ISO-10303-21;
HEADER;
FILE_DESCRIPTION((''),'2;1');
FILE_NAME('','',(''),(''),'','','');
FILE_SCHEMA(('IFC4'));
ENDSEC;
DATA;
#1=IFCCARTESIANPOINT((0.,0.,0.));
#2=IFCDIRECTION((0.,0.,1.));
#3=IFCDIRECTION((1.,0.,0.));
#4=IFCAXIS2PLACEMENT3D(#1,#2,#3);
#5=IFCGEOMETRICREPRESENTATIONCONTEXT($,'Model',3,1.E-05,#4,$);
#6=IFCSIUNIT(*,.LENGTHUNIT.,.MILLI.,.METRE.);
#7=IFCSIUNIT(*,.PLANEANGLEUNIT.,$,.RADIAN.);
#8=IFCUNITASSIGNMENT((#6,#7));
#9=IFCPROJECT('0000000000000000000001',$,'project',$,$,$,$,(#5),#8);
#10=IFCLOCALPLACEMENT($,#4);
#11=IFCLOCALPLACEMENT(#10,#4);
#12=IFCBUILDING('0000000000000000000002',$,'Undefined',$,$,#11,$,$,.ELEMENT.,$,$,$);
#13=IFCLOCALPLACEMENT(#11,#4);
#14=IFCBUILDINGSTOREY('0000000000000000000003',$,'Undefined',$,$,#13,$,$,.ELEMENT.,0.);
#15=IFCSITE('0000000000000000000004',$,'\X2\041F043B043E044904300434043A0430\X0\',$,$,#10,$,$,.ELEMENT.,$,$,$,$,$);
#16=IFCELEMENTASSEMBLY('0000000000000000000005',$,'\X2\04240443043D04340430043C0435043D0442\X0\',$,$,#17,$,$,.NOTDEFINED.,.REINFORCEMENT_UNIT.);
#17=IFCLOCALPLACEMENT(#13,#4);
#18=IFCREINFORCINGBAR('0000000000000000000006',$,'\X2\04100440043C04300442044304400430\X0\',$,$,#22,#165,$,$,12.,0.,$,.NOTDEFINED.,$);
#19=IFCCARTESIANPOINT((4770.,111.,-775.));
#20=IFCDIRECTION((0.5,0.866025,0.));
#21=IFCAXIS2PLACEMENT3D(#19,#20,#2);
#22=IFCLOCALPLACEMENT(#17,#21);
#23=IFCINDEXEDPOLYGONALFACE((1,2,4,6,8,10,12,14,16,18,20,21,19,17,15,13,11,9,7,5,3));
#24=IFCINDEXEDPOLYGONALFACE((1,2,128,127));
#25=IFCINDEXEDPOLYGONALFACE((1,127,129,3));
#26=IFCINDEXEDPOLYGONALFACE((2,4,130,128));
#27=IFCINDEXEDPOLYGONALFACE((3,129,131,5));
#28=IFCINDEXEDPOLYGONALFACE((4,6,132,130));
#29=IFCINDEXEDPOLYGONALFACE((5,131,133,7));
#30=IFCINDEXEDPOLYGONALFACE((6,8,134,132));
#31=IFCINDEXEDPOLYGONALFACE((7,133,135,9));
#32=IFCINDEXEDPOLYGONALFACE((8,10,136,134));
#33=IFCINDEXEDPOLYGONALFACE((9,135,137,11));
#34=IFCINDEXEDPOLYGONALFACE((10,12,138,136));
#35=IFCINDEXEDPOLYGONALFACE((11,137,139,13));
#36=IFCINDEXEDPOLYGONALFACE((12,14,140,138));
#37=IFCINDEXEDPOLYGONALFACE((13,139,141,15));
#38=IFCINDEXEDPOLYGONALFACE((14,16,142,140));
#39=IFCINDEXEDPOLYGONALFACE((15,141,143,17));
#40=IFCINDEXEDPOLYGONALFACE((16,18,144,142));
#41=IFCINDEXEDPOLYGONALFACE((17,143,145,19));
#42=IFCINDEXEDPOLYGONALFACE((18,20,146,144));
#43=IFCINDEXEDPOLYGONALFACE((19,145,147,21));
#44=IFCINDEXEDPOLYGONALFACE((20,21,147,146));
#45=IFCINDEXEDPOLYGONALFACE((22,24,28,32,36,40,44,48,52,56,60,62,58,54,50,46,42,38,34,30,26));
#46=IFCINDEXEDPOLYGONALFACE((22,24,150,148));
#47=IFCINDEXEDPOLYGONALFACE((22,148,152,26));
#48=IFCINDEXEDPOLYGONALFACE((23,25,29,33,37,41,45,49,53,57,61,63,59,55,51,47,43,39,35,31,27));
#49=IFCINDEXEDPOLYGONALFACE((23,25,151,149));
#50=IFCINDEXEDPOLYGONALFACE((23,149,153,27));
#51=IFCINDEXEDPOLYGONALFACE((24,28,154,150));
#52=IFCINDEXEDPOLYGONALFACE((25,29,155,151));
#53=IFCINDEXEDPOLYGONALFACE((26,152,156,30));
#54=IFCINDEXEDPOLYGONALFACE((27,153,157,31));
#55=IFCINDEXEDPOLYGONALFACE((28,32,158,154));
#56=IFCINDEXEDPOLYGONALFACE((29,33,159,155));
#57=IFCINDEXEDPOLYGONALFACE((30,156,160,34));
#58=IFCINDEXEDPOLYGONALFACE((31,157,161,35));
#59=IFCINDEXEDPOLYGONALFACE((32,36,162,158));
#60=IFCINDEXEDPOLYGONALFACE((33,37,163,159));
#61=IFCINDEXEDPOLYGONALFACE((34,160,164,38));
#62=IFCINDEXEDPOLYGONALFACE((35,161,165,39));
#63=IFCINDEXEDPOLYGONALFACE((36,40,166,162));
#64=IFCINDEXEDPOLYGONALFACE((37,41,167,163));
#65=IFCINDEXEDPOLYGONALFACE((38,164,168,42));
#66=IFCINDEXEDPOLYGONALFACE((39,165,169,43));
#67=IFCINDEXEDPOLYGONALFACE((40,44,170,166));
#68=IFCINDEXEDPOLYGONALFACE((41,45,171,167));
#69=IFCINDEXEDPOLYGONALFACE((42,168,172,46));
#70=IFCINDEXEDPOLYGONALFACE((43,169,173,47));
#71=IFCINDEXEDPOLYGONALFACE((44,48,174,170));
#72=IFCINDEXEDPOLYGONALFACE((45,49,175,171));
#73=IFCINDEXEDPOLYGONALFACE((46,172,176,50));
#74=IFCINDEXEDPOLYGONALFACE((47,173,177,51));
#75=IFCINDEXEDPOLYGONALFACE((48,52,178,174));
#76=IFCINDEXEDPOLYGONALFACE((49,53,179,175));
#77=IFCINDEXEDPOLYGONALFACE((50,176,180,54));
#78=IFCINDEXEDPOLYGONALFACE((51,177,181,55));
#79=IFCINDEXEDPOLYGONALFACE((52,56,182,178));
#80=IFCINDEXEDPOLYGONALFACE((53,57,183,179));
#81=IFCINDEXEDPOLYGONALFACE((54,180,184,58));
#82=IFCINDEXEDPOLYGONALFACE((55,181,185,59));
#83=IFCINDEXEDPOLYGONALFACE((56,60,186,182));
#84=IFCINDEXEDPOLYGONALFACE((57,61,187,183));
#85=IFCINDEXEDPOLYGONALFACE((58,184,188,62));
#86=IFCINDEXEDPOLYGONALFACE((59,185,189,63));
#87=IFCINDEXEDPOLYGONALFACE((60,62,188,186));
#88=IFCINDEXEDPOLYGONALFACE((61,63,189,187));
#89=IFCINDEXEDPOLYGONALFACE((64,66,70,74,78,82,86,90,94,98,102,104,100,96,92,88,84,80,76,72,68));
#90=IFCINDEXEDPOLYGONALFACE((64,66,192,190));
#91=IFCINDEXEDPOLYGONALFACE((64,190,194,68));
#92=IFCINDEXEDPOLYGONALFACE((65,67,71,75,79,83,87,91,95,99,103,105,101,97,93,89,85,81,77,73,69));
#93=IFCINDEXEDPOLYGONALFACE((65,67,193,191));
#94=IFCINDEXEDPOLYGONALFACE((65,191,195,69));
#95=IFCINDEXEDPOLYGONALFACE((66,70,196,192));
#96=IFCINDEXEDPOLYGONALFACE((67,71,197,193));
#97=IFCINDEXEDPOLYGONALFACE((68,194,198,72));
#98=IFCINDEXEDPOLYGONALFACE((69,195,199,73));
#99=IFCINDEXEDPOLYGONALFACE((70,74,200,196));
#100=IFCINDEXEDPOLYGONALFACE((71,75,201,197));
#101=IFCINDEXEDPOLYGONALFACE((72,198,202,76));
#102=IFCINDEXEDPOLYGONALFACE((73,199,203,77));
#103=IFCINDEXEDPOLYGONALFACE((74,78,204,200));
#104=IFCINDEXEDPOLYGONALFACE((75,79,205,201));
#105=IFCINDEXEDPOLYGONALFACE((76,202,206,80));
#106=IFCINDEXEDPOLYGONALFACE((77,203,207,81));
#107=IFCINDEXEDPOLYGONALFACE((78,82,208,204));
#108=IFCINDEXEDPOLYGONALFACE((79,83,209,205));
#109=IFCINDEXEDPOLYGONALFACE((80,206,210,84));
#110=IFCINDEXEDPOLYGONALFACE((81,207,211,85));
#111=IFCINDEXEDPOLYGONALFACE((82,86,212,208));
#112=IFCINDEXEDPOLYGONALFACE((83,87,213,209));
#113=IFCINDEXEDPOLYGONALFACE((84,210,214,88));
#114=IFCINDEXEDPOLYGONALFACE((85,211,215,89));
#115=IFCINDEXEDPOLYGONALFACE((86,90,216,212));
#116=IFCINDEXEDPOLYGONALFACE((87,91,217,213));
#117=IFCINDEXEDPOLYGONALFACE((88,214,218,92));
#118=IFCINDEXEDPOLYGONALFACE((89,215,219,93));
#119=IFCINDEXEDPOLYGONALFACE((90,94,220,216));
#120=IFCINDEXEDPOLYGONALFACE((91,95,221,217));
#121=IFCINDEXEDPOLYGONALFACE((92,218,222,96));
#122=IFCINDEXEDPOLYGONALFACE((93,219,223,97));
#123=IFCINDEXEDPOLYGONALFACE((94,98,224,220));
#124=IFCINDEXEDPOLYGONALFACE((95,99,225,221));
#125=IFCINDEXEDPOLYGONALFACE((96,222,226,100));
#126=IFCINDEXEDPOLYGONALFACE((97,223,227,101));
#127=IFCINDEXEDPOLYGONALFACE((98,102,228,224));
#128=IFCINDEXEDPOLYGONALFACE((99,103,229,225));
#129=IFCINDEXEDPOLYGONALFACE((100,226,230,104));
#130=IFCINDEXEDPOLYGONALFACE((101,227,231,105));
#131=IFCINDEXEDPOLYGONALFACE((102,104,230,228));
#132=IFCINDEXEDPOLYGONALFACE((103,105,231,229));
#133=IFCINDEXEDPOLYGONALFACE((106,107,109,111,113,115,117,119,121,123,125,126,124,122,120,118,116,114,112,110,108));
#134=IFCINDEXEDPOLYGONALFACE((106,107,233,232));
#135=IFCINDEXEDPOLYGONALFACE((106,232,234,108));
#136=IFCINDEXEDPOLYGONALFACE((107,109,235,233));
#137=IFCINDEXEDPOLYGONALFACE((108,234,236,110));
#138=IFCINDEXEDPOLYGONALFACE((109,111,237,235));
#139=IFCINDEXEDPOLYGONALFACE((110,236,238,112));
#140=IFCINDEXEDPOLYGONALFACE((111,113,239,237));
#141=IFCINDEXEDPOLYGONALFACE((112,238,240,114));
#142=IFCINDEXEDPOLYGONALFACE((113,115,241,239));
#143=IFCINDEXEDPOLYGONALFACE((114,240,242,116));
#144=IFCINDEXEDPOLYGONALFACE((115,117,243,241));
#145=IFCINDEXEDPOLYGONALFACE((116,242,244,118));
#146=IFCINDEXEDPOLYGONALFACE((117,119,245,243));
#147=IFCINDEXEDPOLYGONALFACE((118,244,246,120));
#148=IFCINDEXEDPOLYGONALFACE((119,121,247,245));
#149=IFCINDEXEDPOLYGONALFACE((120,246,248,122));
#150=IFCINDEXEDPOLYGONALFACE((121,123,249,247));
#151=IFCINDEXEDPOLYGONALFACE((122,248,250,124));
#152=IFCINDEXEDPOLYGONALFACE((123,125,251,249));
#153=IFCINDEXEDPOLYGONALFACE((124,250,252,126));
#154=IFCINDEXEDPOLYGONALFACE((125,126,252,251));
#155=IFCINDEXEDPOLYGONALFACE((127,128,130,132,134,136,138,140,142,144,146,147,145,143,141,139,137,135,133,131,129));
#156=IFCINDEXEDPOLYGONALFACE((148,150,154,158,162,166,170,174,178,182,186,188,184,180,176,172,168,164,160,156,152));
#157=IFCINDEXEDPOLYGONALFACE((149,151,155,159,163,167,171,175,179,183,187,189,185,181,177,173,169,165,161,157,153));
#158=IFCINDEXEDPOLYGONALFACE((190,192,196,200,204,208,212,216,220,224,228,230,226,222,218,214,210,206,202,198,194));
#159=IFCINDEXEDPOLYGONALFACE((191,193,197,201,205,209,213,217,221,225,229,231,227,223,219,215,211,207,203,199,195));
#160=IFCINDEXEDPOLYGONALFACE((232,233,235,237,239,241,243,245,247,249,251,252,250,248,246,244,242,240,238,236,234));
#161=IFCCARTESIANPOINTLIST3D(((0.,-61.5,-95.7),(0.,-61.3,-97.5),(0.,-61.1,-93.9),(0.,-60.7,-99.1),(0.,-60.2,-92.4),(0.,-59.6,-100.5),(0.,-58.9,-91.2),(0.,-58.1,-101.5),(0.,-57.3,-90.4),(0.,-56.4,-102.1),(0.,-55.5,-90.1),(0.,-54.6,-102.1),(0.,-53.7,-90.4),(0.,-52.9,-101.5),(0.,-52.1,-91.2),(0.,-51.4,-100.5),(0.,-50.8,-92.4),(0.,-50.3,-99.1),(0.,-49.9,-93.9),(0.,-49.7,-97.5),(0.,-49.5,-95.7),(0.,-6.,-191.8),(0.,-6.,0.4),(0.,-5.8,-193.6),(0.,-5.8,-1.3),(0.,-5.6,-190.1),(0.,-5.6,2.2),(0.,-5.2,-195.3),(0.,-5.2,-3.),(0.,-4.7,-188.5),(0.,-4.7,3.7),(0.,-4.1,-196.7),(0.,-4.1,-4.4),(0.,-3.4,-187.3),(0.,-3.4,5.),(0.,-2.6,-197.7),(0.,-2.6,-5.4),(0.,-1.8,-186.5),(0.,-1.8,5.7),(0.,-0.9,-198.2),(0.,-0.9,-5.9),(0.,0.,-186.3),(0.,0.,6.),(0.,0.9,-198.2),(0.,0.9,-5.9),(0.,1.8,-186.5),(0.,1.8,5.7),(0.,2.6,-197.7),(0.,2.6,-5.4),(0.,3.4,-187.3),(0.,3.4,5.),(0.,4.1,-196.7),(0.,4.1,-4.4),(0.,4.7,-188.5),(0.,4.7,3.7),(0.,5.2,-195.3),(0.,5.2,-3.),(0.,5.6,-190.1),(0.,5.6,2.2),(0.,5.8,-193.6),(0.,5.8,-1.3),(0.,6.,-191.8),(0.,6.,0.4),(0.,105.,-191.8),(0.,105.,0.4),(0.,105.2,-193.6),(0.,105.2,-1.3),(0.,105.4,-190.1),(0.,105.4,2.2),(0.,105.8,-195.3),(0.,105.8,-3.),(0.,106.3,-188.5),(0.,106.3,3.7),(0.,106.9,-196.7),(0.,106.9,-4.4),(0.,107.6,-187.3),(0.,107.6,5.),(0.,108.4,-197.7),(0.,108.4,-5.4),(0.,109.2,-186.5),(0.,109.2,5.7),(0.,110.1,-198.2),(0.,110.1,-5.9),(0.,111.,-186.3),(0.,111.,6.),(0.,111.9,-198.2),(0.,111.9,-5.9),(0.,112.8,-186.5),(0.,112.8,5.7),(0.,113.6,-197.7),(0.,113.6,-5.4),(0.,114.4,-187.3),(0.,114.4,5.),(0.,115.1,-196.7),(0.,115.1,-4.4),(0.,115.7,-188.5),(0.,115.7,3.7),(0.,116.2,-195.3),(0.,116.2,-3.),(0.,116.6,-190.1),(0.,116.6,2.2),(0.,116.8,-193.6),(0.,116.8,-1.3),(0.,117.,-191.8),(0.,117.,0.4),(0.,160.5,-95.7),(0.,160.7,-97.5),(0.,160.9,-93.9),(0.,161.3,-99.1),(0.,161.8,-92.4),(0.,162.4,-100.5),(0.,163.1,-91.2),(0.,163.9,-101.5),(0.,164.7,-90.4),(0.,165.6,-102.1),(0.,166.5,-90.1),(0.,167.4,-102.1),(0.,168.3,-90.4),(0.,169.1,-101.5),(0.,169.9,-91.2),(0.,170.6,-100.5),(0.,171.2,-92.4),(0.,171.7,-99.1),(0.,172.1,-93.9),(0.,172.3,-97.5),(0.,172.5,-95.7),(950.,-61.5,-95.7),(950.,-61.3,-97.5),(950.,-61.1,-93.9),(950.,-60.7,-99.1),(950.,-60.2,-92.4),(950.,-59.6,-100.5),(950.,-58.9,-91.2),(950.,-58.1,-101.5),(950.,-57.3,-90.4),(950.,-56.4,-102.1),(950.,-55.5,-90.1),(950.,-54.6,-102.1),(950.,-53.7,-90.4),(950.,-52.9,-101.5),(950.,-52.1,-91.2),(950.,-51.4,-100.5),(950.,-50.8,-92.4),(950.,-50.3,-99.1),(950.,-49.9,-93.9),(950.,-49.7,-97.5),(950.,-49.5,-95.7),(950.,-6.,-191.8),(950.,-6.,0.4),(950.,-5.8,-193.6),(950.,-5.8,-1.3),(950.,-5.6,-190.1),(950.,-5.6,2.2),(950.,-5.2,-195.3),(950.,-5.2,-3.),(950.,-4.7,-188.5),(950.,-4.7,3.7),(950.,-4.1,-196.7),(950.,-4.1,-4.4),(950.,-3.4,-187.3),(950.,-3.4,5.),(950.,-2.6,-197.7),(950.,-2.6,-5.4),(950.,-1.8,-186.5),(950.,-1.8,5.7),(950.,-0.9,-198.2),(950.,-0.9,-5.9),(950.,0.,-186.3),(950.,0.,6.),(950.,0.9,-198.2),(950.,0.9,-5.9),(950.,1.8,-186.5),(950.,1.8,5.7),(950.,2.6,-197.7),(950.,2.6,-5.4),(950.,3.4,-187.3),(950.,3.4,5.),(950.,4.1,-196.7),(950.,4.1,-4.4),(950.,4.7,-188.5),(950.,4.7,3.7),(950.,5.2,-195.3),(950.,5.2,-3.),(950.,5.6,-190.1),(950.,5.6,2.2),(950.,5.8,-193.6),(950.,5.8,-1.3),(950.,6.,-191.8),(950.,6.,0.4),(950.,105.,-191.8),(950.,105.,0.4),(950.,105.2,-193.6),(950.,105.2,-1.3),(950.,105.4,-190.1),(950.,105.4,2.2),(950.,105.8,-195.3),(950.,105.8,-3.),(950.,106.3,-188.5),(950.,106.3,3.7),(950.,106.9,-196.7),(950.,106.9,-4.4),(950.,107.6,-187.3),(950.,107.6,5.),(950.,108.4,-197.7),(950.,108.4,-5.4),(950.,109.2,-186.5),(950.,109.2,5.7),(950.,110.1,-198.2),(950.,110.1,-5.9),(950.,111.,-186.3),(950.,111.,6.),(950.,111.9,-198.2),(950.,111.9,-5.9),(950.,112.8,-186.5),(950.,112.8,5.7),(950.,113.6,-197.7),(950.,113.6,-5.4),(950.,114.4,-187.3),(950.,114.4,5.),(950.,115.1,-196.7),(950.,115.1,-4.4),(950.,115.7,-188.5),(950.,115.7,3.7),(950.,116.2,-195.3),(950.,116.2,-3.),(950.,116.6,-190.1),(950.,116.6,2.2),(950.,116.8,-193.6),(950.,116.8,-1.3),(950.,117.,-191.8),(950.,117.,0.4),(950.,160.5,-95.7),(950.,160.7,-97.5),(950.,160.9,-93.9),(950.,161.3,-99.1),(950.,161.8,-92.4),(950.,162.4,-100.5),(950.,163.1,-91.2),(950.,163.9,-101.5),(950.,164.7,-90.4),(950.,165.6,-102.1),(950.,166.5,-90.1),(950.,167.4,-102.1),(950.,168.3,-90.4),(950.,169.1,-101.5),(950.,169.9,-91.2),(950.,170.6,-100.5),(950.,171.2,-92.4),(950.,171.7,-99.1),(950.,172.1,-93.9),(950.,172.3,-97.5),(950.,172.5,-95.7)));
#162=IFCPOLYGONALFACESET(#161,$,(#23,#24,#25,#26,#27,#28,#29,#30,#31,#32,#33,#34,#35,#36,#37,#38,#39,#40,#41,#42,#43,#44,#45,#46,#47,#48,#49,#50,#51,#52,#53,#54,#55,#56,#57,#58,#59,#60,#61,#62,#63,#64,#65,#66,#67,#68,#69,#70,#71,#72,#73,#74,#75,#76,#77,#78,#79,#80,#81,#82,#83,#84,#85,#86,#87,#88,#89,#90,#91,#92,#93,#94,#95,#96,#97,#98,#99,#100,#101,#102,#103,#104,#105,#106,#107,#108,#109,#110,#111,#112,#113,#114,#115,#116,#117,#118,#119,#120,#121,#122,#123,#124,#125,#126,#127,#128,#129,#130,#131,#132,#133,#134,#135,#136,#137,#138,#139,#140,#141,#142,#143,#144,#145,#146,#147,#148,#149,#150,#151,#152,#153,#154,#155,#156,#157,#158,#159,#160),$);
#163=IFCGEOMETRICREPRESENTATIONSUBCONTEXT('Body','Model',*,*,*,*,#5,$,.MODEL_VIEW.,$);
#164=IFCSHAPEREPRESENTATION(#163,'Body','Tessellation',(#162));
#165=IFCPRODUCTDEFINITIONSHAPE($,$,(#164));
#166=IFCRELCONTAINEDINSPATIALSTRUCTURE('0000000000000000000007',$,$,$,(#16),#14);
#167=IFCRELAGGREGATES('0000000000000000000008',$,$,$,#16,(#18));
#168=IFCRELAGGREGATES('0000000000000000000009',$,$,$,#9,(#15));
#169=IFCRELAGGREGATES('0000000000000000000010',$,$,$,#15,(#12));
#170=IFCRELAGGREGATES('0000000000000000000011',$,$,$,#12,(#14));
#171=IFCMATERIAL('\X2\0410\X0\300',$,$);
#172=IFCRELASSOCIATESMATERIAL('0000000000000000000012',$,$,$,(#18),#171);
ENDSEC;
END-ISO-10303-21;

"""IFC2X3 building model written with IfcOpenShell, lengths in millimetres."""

from ifc_helpers import new_model, entity, si_unit, frame, origin_with_axes, place, context, subcontext, project, spatial, source, transform, mapped, material, element, aggregate, save


model = new_model("IFC2X3")

# Units and contexts
model_context = context("Model", 3, precision=1e-05, world=origin_with_axes())
body_context = subcontext(model_context, "Body", "Model", "MODEL_VIEW")
ifc_project = project(units=[si_unit("LENGTHUNIT", "METRE", prefix="MILLI"), si_unit("PLANEANGLEUNIT", "RADIAN")], contexts=[model_context])

# Site, building, storey
site_placement = place(None, origin_with_axes())
site = spatial("IfcSite", under=ifc_project, at=site_placement, Name="Площадка", CompositionType="ELEMENT")
building_placement = place(site_placement, origin_with_axes())
building = spatial("IfcBuilding", under=site, at=building_placement, Name="Undefined", CompositionType="ELEMENT")
storey_placement = place(building_placement, origin_with_axes())
storey = spatial("IfcBuildingStorey", under=building, at=storey_placement, Name="Undefined", CompositionType="ELEMENT", Elevation=0.0)

# Element assembly
assembly_1_placement = place(storey_placement, origin_with_axes())
assembly_1 = element("IfcElementAssembly", 1, at=assembly_1_placement, inside=storey, Name="Фундамент", AssemblyPlace="NOTDEFINED", PredefinedType="REINFORCEMENT_UNIT")

# Reinforcing bar
ifc_material_1 = material(Name="А300")
shared_shape_1 = source(origin_with_axes(), body_context, "Body", "AdvancedSweptSolid", [
    entity("IfcSweptDiskSolid", entity("IfcTrimmedCurve", entity("IfcLine", entity("IfcCartesianPoint", [0.0, 0.0, 0.0]), entity("IfcVector", entity("IfcDirection", [1.0, 0.0, 0.0]), 1.0)), [entity("IfcParameterValue", 0.0)], [entity("IfcParameterValue", 950.0)], True, "PARAMETER"), 6.0, None, 0.0, 950.0),
])
shared_shape_2 = source(origin_with_axes(), body_context, "Body", "AdvancedSweptSolid", [
    entity("IfcSweptDiskSolid", entity("IfcTrimmedCurve", entity("IfcLine", entity("IfcCartesianPoint", [0.0, 0.0, 0.0]), entity("IfcVector", entity("IfcDirection", [1.0, 0.0, 0.0]), 1.0)), [entity("IfcParameterValue", 0.0)], [entity("IfcParameterValue", 950.0)], True, "PARAMETER"), 6.0, None, 0.0, 950.0),
])
shared_shape_3 = source(origin_with_axes(), body_context, "Body", "AdvancedSweptSolid", [
    entity("IfcSweptDiskSolid", entity("IfcTrimmedCurve", entity("IfcLine", entity("IfcCartesianPoint", [0.0, 0.0, 0.0]), entity("IfcVector", entity("IfcDirection", [1.0, 0.0, 0.0]), 1.0)), [entity("IfcParameterValue", 0.0)], [entity("IfcParameterValue", 950.0)], True, "PARAMETER"), 6.0, None, 0.0, 950.0),
])
shared_shape_4 = source(origin_with_axes(), body_context, "Body", "AdvancedSweptSolid", [
    entity("IfcSweptDiskSolid", entity("IfcTrimmedCurve", entity("IfcLine", entity("IfcCartesianPoint", [0.0, 0.0, 0.0]), entity("IfcVector", entity("IfcDirection", [1.0, 0.0, 0.0]), 1.0)), [entity("IfcParameterValue", 0.0)], [entity("IfcParameterValue", 950.0)], True, "PARAMETER"), 6.0, None, 0.0, 950.0),
])
shared_shape_5 = source(origin_with_axes(), body_context, "Body", "AdvancedSweptSolid", [
    entity("IfcSweptDiskSolid", entity("IfcTrimmedCurve", entity("IfcLine", entity("IfcCartesianPoint", [0.0, 0.0, 0.0]), entity("IfcVector", entity("IfcDirection", [1.0, 0.0, 0.0]), 1.0)), [entity("IfcParameterValue", 0.0)], [entity("IfcParameterValue", 950.0)], True, "PARAMETER"), 6.0, None, 0.0, 950.0),
])
shared_shape_6 = source(origin_with_axes(), body_context, "Body", "AdvancedSweptSolid", [
    entity("IfcSweptDiskSolid", entity("IfcTrimmedCurve", entity("IfcLine", entity("IfcCartesianPoint", [0.0, 0.0, 0.0]), entity("IfcVector", entity("IfcDirection", [1.0, 0.0, 0.0]), 1.0)), [entity("IfcParameterValue", 0.0)], [entity("IfcParameterValue", 950.0)], True, "PARAMETER"), 6.0, None, 0.0, 950.0),
])
reinforcing_bar_1_placement = place(assembly_1_placement, frame((4770.0, 111.0, -775.0), z_axis=(0.5, 0.866025, 0.0), x_axis=(0.0, 0.0, 1.0)))
reinforcing_bar_1 = element("IfcReinforcingBar", 2, at=reinforcing_bar_1_placement, material=ifc_material_1, Name="Арматура", BarRole="NOTDEFINED", CrossSectionArea=0.0, NominalDiameter=12.0, context=body_context, shape_type="MappedRepresentation", body=[
    mapped(shared_shape_1, transform((0.0, 0.0, 0.0))),
    mapped(shared_shape_2, transform((0.0, -55.5, -96.1))),
    mapped(shared_shape_3, transform((0.0, 0.0, -192.3))),
    mapped(shared_shape_4, transform((0.0, 111.0, -192.3))),
    mapped(shared_shape_5, transform((0.0, 166.5, -96.1))),
    mapped(shared_shape_6, transform((0.0, 111.0, 0.0))),
])
aggregate(assembly_1, [reinforcing_bar_1])

save(model, "model.ifc")
